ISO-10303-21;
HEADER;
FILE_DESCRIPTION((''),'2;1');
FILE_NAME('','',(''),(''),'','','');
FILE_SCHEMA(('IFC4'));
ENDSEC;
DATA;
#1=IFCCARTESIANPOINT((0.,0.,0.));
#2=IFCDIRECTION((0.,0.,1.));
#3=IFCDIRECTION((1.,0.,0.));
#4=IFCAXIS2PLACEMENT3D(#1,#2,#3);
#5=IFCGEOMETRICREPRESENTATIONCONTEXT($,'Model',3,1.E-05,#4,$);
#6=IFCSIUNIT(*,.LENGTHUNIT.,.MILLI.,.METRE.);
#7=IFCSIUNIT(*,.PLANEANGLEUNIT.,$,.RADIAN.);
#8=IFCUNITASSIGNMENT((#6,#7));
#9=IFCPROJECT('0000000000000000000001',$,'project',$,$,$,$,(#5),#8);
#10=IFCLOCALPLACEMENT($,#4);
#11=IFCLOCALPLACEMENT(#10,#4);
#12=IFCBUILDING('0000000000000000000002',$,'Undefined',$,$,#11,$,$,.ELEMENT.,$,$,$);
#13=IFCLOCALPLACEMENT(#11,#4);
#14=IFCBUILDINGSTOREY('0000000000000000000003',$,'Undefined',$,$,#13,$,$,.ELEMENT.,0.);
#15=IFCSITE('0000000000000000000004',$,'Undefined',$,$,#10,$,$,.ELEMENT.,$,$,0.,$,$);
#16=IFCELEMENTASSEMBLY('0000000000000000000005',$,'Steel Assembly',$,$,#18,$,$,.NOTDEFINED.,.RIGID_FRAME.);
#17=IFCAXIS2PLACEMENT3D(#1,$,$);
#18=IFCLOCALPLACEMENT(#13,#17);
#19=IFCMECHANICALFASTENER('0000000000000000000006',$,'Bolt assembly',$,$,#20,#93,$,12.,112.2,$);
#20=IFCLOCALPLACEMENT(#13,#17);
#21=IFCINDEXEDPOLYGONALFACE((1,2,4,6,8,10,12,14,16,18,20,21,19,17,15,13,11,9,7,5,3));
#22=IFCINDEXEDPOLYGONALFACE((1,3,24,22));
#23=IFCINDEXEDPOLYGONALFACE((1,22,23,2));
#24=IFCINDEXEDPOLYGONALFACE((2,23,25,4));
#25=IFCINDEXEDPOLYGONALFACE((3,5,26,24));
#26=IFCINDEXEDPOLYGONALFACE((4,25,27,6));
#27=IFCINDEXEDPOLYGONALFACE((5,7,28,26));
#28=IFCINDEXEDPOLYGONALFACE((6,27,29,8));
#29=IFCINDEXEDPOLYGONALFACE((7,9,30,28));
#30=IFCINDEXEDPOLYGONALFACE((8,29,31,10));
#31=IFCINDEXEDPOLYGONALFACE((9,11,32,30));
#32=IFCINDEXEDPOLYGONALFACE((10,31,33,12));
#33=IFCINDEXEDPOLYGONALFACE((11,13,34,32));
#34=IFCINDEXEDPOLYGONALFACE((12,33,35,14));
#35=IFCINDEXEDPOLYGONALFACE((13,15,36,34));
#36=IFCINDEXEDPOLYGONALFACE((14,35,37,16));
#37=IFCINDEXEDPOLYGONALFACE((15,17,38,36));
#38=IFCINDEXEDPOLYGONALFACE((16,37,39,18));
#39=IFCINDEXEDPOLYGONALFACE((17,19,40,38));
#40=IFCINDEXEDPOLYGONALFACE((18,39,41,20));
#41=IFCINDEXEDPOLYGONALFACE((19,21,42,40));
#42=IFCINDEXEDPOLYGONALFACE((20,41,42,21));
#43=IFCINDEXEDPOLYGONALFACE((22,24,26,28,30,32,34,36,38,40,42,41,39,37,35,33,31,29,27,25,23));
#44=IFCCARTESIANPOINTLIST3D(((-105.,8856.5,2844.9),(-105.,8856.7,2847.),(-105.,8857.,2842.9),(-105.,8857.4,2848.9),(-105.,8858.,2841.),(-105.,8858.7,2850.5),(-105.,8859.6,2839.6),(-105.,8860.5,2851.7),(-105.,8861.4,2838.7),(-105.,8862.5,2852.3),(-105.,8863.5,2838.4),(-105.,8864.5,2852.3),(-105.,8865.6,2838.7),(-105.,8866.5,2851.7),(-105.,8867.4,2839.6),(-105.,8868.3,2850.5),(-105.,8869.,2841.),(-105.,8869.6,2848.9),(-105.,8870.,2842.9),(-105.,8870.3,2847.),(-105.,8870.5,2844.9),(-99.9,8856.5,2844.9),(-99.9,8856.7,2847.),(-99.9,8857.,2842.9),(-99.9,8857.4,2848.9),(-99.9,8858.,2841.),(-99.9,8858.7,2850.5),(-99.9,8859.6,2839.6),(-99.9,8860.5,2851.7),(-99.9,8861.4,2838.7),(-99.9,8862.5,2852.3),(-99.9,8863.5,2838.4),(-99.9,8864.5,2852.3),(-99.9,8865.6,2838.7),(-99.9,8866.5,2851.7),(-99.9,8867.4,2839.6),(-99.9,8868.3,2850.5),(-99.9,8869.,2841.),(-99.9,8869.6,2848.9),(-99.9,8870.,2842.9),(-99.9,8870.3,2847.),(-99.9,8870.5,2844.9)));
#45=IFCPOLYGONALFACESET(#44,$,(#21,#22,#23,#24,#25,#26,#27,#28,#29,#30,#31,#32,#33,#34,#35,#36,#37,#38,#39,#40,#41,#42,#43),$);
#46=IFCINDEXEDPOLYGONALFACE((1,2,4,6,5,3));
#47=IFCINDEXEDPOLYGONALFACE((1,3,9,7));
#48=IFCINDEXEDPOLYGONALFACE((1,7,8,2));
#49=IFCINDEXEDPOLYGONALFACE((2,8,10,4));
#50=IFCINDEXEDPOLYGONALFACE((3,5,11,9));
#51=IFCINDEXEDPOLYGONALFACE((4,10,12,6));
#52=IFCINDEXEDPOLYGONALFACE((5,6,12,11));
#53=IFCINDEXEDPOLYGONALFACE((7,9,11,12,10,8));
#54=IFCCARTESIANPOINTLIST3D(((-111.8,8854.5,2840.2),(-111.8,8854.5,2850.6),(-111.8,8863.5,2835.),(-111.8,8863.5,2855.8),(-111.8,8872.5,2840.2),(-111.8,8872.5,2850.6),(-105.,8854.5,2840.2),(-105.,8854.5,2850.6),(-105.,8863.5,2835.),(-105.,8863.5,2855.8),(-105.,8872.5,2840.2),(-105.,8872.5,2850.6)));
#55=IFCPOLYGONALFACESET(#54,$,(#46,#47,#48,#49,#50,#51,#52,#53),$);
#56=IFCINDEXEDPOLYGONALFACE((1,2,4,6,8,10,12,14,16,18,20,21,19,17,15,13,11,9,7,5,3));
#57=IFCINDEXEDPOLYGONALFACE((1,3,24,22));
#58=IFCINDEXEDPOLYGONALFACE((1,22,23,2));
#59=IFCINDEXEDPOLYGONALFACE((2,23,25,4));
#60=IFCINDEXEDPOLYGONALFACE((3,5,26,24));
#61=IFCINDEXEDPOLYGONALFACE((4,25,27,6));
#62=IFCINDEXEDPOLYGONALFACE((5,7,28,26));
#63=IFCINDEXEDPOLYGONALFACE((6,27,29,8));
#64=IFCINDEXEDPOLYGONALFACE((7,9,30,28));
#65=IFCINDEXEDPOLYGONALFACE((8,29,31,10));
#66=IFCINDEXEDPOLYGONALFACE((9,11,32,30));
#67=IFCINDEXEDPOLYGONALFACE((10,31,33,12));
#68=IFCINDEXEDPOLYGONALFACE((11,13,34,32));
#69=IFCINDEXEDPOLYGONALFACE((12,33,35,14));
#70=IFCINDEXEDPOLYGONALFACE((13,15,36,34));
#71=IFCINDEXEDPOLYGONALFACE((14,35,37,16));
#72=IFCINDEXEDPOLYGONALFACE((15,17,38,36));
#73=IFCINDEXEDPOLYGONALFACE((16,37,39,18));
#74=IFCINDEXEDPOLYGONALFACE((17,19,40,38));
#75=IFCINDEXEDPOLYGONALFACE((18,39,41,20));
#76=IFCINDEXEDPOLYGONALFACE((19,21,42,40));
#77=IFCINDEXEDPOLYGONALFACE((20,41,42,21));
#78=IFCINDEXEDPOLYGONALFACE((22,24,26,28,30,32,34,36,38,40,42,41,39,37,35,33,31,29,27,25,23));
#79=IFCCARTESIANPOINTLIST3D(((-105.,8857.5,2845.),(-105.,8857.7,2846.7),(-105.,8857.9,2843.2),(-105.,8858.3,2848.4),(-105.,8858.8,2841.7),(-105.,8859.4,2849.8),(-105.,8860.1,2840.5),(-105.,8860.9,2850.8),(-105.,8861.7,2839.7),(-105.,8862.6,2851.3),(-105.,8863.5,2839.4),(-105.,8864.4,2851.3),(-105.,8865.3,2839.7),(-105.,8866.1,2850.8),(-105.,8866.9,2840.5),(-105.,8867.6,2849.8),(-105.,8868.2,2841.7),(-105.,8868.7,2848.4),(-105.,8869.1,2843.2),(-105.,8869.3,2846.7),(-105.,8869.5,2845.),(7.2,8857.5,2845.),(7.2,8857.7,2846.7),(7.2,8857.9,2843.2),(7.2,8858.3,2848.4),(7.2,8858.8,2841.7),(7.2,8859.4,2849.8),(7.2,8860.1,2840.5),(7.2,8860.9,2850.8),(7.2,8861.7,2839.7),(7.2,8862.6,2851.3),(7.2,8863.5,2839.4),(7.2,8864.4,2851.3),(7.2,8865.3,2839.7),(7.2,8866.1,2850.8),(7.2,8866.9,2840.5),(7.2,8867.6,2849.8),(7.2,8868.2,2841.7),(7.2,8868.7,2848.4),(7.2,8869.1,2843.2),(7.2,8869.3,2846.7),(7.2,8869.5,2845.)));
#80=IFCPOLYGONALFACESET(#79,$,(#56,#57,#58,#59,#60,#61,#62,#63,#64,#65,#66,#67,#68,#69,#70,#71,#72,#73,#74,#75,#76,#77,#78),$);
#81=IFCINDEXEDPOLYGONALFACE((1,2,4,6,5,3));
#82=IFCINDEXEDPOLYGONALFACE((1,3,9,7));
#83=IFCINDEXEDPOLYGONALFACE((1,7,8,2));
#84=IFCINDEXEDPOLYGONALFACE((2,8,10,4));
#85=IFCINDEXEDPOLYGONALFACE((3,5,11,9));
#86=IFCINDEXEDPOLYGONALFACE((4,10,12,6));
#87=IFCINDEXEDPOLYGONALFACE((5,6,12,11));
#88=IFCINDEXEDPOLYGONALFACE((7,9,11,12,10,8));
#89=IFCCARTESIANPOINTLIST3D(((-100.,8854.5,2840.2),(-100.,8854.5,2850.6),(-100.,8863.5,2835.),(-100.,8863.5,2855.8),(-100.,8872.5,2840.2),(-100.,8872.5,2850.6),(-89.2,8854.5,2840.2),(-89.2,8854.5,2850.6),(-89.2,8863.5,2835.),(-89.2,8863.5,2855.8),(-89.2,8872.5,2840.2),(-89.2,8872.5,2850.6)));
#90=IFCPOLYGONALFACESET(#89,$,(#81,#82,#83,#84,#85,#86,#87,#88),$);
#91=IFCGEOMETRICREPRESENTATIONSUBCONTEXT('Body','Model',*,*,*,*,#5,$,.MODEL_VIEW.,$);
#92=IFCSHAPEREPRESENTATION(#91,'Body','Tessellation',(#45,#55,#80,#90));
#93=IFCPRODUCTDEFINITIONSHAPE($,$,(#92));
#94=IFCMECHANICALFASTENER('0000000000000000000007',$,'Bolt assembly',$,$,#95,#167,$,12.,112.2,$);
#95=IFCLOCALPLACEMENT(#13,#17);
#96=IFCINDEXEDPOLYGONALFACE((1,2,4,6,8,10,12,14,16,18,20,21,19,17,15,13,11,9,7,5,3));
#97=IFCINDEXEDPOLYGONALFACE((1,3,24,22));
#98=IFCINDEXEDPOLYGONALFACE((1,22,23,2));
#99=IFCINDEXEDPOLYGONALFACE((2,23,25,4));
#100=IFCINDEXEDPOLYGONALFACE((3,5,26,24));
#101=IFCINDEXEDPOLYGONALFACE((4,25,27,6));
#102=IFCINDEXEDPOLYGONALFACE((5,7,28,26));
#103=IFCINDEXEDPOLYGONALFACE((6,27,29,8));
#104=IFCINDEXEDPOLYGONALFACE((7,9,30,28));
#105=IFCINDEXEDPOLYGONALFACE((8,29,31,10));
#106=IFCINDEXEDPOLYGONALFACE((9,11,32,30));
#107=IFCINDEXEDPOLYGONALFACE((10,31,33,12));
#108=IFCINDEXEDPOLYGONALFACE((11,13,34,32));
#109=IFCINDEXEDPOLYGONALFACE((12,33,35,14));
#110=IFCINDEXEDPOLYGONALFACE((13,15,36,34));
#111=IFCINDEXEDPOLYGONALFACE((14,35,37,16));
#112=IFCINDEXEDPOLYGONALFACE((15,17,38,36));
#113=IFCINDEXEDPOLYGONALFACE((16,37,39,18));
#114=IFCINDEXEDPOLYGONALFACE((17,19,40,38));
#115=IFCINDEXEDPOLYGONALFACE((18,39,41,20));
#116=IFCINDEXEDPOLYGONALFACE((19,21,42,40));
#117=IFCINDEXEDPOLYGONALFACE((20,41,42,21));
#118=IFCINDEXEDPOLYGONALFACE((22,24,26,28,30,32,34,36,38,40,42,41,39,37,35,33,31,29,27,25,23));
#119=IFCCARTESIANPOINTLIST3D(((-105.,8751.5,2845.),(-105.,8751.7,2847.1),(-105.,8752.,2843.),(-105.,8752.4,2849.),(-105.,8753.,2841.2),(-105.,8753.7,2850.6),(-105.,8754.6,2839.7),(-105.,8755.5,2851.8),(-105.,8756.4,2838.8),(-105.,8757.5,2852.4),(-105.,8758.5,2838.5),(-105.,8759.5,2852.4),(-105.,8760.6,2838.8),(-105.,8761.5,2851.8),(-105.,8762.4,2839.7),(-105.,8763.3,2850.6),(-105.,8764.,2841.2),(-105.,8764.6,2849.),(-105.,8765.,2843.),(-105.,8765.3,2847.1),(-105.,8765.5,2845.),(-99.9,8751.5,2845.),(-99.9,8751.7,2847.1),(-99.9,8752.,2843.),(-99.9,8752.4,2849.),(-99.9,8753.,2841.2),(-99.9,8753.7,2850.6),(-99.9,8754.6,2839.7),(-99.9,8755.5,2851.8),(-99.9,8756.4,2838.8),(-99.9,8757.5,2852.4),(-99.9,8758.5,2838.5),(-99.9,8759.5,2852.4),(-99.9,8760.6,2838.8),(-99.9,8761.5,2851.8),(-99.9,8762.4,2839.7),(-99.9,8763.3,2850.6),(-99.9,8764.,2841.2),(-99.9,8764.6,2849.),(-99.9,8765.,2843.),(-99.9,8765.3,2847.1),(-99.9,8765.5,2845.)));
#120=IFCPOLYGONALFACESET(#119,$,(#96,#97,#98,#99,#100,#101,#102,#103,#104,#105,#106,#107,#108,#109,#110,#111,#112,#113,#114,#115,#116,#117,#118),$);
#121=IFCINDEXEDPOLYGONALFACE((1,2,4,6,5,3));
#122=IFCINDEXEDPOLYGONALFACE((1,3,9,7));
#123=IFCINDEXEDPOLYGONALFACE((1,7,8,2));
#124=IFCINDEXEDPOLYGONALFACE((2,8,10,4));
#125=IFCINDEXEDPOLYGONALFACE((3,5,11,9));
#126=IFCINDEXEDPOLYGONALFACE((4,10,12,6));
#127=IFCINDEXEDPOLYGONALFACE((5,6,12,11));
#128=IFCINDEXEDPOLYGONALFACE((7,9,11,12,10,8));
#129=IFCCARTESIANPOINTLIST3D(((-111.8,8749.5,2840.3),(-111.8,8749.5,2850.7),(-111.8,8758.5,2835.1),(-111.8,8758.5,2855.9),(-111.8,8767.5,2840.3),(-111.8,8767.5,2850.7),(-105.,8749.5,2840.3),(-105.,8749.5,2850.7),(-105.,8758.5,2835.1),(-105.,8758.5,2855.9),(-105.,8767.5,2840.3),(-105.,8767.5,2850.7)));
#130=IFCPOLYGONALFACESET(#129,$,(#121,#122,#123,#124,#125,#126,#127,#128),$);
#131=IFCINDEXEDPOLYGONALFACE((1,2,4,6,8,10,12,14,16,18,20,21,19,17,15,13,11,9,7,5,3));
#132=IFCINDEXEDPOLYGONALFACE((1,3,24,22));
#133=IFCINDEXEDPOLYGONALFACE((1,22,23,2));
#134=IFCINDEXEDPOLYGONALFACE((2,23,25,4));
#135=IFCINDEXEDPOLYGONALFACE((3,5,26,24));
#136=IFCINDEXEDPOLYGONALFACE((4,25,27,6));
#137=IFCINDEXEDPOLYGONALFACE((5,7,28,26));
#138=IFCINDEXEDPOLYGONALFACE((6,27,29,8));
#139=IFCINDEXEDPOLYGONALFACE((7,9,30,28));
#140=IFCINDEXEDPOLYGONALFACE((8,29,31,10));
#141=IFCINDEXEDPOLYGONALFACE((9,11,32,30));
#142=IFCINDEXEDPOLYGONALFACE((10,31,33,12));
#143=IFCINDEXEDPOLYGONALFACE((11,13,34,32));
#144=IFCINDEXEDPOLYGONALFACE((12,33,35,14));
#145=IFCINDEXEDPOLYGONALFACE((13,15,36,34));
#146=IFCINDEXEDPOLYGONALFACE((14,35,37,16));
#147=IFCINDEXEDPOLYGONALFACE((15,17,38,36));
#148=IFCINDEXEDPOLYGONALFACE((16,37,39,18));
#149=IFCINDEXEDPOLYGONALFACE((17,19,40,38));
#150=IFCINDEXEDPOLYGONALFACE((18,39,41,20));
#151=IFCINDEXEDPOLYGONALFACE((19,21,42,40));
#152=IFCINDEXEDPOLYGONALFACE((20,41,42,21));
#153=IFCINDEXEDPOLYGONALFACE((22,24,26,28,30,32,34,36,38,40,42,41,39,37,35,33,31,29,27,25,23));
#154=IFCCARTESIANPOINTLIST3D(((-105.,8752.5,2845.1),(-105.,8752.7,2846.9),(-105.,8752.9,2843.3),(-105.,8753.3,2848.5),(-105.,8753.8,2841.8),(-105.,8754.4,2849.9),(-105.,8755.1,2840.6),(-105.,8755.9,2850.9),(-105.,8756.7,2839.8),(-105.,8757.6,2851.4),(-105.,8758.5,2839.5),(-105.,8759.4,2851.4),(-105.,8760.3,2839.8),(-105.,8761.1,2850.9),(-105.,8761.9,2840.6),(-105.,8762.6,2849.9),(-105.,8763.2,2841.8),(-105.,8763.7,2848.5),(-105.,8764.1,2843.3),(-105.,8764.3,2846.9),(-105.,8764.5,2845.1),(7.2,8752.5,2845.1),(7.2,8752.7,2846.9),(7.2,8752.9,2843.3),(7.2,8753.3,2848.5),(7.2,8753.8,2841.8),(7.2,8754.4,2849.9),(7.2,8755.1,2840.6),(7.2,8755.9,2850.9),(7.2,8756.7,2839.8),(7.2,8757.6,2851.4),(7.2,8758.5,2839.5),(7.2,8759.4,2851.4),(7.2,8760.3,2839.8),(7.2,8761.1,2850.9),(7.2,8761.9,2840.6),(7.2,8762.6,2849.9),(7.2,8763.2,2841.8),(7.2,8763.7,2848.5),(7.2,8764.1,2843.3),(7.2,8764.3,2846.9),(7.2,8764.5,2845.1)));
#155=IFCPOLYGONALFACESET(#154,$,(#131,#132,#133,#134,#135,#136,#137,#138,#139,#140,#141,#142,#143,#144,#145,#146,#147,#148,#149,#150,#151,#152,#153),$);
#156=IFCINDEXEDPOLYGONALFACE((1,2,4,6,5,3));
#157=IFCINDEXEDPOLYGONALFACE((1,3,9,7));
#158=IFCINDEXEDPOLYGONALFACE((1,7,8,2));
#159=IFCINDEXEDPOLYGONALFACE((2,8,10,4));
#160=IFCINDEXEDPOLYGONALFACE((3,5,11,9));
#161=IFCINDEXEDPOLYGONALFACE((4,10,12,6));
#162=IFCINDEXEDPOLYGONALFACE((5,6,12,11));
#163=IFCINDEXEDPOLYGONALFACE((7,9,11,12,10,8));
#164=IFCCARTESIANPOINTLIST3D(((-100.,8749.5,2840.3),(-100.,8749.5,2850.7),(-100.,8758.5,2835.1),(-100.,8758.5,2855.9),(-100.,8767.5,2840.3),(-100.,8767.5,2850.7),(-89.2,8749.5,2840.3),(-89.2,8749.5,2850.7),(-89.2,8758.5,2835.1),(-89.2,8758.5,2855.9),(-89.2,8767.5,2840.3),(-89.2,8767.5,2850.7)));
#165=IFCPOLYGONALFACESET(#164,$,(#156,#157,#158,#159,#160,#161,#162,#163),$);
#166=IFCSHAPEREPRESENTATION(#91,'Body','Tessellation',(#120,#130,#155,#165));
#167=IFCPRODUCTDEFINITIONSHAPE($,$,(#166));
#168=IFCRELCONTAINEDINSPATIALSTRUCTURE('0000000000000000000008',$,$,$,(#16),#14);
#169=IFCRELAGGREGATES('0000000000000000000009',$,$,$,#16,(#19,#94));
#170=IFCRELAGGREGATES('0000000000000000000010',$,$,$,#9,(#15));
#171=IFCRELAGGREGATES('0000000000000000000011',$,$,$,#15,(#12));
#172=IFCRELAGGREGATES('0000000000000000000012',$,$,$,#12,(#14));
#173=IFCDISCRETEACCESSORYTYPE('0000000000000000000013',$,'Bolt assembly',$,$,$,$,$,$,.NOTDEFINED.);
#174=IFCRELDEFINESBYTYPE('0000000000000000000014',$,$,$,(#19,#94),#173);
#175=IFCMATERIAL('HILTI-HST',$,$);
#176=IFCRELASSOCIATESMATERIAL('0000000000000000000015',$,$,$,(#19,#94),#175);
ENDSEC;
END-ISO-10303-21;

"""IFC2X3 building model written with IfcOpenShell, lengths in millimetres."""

from ifc_helpers import new_model, si_unit, frame, origin_with_axes, origin_2d_with_axis, place, context, subcontext, project, spatial, polyline, circle, outline, extrude, source, transform, mapped, material, type_object, element, aggregate, save


model = new_model("IFC2X3")

# Units and contexts
model_context = context("Model", 3, precision=1e-05, world=origin_with_axes())
body_context = subcontext(model_context, "Body", "Model", "MODEL_VIEW")
ifc_project = project(units=[si_unit("LENGTHUNIT", "METRE", prefix="MILLI"), si_unit("PLANEANGLEUNIT", "RADIAN")], contexts=[model_context])

# Site, building, storey
site_placement = place(None, origin_with_axes())
site = spatial("IfcSite", under=ifc_project, at=site_placement, Name="Undefined", CompositionType="ELEMENT", RefElevation=0.0)
building_placement = place(site_placement, origin_with_axes())
building = spatial("IfcBuilding", under=site, at=building_placement, Name="Undefined", CompositionType="ELEMENT")
storey_placement = place(building_placement, origin_with_axes())
storey = spatial("IfcBuildingStorey", under=building, at=storey_placement, Name="Undefined", CompositionType="ELEMENT", Elevation=0.0)

# Element assembly
assembly_1_placement = place(storey_placement, origin_with_axes())
assembly_1 = element("IfcElementAssembly", 1, at=assembly_1_placement, inside=storey, Name="Steel Assembly", AssemblyPlace="NOTDEFINED", PredefinedType="RIGID_FRAME")

# Shared definitions
discrete_accessory_type_1 = type_object("IfcDiscreteAccessoryType", Name="Bolt assembly")

# Mechanical fasteners
ifc_material_1 = material(Name="HILTI-HST")
shared_shape_1 = source(origin_with_axes(), body_context, "Body", "SweptSolid", [
    extrude(circle(Radius=7.0, at=origin_2d_with_axis()), frame((0.0, -5.0, 0.0), z_axis=(0.0, 1.0, 0.0), x_axis=(1.0, 0.0, 0.0)), (0.0, 0.0, 1.0), 5.1),
    extrude(outline(polyline([(10.4, 0.0), (5.2, 9.0), (-5.2, 9.0), (-10.4, 0.0), (-5.2, -9.0), (5.2, -9.0), (10.4, 0.0)])), frame((0.0, -11.8, 0.0), z_axis=(0.0, 1.0, 0.0), x_axis=(1.0, 0.0, 0.0)), (0.0, 0.0, 1.0), 6.8),
    extrude(circle(Radius=6.0, at=origin_2d_with_axis()), frame((0.0, -5.0, 0.0), z_axis=(0.0, 1.0, 0.0), x_axis=(1.0, 0.0, 0.0)), (0.0, 0.0, 1.0), 112.2),
    extrude(outline(polyline([(10.4, 0.0), (5.2, 9.0), (-5.2, 9.0), (-10.4, 0.0), (-5.2, -9.0), (5.2, -9.0), (10.4, 0.0)])), frame((0.0, 0.0, 0.0), z_axis=(0.0, 1.0, 0.0), x_axis=(1.0, 0.0, 0.0)), (0.0, 0.0, 1.0), 10.8),
])
mechanical_fastener_1_placement = place(assembly_1_placement, frame((-100.0, 8863.5, 2845.4), z_axis=(0.0, -1.0, 0.0), x_axis=(0.0, 0.0, -1.0)))
mechanical_fastener_1 = element("IfcMechanicalFastener", 2, at=mechanical_fastener_1_placement, type_object=discrete_accessory_type_1, material=ifc_material_1, Name="Bolt assembly", NominalDiameter=12.0, NominalLength=112.2, context=body_context, shape_type="MappedRepresentation", body=[
    mapped(shared_shape_1, transform((0.0, 0.0, 0.0))),
])
mechanical_fastener_2_placement = place(assembly_1_placement, frame((-100.0, 8758.5, 2845.5), z_axis=(0.0, -1.0, 0.0), x_axis=(0.0, 0.0, -1.0)))
mechanical_fastener_2 = element("IfcMechanicalFastener", 3, at=mechanical_fastener_2_placement, type_object=discrete_accessory_type_1, material=ifc_material_1, Name="Bolt assembly", NominalDiameter=12.0, NominalLength=112.2, context=body_context, shape_type="MappedRepresentation", body=[
    mapped(shared_shape_1, transform((0.0, 0.0, 0.0))),
])
aggregate(assembly_1, [mechanical_fastener_1, mechanical_fastener_2])

save(model, "model.ifc")
